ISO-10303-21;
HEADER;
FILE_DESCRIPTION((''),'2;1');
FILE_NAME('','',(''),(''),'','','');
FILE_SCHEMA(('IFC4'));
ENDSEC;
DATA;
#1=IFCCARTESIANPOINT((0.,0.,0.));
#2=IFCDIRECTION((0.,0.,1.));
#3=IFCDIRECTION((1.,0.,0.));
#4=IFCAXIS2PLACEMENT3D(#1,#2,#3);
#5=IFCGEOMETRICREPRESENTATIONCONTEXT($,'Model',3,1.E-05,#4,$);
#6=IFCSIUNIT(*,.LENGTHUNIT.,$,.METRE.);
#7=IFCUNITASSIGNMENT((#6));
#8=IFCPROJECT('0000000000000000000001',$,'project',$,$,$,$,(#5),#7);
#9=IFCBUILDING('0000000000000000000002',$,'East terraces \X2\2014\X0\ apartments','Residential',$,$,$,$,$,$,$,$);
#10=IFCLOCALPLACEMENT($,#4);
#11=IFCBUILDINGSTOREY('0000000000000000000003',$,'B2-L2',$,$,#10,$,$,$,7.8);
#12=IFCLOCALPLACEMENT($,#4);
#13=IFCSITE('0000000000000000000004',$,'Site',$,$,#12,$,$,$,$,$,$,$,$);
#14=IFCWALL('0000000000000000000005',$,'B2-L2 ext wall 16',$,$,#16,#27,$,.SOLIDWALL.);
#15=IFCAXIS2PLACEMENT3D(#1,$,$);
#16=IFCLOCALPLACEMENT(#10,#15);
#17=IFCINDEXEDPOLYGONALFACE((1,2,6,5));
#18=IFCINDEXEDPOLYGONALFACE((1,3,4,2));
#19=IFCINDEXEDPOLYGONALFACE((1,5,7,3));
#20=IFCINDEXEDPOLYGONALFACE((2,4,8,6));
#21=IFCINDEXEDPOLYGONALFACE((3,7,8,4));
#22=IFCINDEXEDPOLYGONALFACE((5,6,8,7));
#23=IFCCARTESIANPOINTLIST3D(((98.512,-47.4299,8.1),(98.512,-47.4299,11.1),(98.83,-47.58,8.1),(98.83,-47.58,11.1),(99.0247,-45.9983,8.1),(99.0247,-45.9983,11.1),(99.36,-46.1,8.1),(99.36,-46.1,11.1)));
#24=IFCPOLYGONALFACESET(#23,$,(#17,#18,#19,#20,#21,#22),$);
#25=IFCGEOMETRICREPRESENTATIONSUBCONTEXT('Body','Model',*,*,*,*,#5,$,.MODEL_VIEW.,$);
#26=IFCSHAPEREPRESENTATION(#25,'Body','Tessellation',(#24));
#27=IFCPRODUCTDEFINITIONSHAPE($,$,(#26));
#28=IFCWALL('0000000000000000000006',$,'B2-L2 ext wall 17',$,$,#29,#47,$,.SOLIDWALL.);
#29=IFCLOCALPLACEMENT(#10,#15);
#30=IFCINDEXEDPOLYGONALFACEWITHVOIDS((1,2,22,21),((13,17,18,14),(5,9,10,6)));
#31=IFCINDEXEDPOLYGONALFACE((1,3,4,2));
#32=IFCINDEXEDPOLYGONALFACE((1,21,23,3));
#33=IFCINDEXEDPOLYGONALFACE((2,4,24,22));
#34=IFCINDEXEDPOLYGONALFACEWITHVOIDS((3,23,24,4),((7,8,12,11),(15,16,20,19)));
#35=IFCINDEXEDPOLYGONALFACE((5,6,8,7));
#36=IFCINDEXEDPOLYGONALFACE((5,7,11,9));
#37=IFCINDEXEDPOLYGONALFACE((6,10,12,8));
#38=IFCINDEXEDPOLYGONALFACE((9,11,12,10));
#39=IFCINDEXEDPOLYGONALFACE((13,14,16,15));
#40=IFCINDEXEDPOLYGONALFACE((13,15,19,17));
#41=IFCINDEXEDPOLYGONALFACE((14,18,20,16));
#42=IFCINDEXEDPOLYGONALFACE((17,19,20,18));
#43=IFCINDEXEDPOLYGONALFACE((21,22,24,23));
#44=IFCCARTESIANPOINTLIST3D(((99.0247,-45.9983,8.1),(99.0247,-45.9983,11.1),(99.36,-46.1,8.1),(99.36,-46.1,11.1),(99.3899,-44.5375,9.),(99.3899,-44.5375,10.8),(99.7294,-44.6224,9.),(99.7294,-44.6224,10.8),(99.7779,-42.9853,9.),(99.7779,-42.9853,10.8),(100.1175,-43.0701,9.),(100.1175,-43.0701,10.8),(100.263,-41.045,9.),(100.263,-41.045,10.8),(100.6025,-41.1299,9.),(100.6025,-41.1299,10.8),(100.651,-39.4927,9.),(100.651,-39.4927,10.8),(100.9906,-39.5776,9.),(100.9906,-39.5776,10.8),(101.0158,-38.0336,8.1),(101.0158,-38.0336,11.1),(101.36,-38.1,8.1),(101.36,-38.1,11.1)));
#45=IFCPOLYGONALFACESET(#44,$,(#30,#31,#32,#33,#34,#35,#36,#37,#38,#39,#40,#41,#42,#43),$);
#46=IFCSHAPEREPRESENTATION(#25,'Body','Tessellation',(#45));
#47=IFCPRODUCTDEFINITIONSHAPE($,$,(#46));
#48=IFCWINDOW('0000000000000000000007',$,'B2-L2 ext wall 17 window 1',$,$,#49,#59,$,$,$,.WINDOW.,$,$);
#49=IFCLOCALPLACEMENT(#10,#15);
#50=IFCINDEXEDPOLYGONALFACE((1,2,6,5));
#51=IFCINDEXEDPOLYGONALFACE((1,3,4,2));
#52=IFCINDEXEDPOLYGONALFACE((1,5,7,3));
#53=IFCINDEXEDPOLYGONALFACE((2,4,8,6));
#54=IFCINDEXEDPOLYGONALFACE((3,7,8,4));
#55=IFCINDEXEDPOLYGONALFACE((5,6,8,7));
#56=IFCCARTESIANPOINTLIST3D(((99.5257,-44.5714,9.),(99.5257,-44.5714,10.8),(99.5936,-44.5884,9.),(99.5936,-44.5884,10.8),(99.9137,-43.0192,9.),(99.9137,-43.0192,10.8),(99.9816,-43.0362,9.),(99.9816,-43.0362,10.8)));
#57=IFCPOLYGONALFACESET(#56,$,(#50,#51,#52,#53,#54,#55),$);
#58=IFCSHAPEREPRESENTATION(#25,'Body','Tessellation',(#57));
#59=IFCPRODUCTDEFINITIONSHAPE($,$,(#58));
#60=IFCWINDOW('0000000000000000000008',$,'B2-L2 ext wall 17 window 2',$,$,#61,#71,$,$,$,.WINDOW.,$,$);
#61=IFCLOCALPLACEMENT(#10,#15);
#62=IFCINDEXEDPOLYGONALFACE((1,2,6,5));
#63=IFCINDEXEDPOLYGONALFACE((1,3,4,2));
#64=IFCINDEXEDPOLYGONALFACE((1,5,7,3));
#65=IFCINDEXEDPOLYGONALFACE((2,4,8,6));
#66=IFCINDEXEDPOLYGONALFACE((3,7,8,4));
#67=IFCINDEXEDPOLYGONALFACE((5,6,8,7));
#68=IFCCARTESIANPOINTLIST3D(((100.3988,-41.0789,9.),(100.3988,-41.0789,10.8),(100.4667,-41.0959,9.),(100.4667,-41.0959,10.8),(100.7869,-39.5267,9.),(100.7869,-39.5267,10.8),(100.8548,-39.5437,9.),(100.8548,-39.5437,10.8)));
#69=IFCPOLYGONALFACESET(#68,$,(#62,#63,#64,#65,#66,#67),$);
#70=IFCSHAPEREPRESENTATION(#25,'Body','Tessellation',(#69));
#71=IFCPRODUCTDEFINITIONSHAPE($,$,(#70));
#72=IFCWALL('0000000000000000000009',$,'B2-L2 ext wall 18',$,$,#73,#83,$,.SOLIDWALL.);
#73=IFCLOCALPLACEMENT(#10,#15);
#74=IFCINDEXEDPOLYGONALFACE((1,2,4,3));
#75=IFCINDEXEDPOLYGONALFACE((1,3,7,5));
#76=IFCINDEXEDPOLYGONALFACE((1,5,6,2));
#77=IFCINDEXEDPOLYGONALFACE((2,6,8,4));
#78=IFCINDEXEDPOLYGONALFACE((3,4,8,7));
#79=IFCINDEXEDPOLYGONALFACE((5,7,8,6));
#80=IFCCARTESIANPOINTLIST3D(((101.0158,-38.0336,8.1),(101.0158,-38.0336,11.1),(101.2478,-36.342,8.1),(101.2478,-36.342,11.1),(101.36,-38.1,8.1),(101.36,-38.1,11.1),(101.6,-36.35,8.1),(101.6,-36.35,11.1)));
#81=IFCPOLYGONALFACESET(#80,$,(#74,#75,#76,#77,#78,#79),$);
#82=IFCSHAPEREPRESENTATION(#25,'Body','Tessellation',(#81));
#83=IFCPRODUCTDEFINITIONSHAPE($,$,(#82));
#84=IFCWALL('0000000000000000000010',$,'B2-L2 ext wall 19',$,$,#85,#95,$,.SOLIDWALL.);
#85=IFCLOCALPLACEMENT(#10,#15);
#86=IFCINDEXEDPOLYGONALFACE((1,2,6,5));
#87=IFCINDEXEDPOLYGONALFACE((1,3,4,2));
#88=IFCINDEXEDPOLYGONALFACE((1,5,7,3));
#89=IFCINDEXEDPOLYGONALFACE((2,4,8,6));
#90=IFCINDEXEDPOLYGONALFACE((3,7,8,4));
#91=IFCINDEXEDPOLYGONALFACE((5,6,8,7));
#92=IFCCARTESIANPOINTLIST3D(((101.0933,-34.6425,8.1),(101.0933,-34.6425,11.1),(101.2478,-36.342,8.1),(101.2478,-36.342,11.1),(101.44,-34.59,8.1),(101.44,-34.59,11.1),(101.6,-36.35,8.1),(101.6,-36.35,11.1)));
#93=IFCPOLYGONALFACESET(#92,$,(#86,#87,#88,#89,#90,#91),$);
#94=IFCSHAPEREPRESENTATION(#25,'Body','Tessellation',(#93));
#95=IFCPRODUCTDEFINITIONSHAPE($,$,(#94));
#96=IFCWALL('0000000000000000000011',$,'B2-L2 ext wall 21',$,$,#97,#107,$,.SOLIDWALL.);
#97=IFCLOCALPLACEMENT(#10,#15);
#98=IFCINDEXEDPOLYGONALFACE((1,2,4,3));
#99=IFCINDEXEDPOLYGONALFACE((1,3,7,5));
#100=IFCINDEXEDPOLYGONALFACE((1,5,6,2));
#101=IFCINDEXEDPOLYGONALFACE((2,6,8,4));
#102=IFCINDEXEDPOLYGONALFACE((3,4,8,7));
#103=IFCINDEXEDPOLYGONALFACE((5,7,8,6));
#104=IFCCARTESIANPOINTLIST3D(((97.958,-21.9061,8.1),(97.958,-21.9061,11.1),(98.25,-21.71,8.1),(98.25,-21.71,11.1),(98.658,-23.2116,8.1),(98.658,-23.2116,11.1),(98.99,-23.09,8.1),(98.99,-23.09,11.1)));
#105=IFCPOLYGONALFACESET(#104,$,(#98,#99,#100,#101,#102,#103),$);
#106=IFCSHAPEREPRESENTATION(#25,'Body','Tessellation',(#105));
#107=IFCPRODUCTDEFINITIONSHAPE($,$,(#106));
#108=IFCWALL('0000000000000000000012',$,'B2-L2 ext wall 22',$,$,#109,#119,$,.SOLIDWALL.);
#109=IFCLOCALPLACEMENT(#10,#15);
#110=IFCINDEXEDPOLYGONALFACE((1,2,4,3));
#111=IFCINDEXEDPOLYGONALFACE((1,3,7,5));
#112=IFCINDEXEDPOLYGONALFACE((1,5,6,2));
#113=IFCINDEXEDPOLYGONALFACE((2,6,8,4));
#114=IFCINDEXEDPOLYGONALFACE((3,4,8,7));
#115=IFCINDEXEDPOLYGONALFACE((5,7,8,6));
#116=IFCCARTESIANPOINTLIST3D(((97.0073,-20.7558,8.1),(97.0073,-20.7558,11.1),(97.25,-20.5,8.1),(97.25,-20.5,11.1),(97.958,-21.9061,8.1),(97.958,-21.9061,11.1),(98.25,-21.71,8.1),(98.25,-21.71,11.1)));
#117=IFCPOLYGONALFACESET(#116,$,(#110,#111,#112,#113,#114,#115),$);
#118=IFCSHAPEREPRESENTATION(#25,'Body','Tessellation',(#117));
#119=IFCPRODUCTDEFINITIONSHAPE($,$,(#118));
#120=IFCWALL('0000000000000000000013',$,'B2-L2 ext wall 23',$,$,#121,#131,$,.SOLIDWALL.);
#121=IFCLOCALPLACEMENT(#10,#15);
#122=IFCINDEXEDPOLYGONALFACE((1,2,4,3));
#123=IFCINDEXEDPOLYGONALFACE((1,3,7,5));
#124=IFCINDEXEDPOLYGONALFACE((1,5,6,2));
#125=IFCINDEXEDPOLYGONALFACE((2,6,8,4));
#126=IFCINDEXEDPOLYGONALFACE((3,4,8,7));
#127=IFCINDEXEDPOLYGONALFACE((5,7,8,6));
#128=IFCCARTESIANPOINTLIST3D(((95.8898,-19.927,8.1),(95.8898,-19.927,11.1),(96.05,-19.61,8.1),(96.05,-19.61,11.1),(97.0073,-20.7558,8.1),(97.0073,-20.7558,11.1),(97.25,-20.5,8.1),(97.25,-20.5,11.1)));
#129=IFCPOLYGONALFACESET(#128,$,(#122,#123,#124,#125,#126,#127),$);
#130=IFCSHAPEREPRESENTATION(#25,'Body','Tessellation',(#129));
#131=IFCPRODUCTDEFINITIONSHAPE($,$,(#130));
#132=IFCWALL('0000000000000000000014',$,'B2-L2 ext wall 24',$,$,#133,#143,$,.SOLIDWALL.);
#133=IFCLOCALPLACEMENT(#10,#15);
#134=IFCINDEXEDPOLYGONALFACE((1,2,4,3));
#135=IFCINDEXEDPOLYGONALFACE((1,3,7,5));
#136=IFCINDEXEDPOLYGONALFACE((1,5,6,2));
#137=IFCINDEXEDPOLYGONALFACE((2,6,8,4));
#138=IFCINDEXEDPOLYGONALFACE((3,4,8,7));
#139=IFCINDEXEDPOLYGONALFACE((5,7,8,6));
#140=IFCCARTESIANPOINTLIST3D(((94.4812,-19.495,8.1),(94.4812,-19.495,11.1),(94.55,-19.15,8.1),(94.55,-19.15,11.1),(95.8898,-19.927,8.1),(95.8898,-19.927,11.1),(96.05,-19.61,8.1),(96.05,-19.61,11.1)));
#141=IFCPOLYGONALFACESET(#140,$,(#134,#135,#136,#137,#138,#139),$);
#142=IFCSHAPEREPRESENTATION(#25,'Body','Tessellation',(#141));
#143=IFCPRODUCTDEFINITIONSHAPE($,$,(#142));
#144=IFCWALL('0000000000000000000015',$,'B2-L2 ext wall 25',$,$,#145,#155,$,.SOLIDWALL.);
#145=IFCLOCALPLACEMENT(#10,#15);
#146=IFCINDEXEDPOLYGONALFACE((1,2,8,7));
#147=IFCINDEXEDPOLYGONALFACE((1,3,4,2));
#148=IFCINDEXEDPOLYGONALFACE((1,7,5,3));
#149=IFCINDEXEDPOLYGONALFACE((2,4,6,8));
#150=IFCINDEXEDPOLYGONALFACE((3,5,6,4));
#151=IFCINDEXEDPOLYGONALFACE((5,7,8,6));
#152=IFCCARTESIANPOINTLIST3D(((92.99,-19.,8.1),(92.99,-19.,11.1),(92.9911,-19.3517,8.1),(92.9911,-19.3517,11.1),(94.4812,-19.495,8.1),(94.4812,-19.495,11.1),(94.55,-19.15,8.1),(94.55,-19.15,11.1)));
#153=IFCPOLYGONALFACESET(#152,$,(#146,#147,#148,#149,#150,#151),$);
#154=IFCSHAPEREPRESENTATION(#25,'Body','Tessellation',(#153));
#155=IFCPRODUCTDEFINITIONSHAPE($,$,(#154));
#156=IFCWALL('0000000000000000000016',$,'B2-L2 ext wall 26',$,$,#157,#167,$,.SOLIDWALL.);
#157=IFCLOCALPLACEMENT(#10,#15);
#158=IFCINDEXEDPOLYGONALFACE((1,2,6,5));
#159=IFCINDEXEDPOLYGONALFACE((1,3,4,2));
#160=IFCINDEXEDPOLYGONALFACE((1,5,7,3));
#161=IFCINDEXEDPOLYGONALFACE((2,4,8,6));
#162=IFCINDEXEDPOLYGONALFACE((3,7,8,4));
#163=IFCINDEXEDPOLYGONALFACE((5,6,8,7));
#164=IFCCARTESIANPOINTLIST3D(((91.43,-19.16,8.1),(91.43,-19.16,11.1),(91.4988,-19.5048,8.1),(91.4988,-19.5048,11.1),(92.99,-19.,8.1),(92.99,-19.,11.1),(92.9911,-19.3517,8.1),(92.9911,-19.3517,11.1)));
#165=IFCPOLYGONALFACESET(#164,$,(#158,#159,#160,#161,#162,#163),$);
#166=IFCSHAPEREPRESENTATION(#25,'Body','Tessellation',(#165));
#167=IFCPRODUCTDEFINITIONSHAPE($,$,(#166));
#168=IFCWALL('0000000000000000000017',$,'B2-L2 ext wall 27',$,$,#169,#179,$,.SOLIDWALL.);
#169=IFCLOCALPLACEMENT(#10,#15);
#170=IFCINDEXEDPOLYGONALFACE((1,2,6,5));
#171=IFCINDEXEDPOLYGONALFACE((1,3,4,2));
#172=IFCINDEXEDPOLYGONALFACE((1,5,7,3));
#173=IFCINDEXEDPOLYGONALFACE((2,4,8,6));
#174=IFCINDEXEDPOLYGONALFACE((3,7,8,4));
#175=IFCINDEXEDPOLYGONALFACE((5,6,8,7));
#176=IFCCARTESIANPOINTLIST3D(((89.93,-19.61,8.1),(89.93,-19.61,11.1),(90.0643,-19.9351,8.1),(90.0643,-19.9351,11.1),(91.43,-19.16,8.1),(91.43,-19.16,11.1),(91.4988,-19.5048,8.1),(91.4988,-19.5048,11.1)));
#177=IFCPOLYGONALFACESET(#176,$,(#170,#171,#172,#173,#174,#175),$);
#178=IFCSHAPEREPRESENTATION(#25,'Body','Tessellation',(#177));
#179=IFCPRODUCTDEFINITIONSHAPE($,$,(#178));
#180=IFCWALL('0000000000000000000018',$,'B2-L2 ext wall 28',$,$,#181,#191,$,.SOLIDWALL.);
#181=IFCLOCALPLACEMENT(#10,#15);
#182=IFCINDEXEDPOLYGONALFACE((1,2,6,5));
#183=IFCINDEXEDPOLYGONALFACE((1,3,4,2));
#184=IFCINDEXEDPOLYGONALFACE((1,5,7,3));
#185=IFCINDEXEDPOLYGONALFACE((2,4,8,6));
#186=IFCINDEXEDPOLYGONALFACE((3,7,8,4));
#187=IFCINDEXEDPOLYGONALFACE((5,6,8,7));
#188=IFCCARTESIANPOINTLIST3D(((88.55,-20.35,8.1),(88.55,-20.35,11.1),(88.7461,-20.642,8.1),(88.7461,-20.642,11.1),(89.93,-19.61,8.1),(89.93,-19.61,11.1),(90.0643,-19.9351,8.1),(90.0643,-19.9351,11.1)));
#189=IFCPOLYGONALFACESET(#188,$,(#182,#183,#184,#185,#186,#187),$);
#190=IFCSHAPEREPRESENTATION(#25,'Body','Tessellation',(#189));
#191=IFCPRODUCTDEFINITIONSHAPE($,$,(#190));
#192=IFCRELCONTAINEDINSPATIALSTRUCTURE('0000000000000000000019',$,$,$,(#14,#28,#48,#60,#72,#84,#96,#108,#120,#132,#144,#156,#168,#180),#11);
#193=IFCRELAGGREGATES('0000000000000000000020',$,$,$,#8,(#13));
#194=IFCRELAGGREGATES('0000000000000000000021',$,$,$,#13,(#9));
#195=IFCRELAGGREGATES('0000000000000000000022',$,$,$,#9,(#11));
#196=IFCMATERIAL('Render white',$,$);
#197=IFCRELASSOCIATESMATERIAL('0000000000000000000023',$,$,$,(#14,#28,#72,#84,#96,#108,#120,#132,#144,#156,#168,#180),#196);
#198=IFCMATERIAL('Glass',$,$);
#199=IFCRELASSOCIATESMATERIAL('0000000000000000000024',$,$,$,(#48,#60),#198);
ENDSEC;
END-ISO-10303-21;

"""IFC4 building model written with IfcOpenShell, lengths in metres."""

from ifc_helpers import new_model, si_unit, frame, origin_with_axes, place, context, subcontext, project, spatial, polyline, outline, extrude, material, element, fill, save


model = new_model("IFC4")

# Units and contexts
model_context = context("Model", 3, precision=1e-05, world=origin_with_axes())
body_context = subcontext(model_context, "Body", "Model", "MODEL_VIEW")
ifc_project = project(units=[si_unit("LENGTHUNIT", "METRE")], contexts=[model_context])

# Site, building, storey
site_placement = place(None, origin_with_axes())
site = spatial("IfcSite", under=ifc_project, at=site_placement, Name="Site")
building = spatial("IfcBuilding", under=site, Name="East terraces — apartments", Description="Residential")
storey_placement = place(None, origin_with_axes())
storey = spatial("IfcBuildingStorey", under=building, at=storey_placement, Name="B2-L2", Elevation=7.8)

# Wall
ifc_material_1 = material(Name="Render white")
wall_1_placement = place(storey_placement, origin_with_axes())
element("IfcWall", 1, at=wall_1_placement, inside=storey, material=ifc_material_1, Name="B2-L2 ext wall 16", PredefinedType="SOLIDWALL", context=body_context, shape_type="SweptSolid", body=[
    extrude(outline(polyline([(98.83, -47.58), (99.36, -46.1), (99.0247, -45.9983), (98.512, -47.4299), (98.83, -47.58)])), frame((0.0, 0.0, 8.1), z_axis=(0.0, 0.0, 1.0), x_axis=(1.0, 0.0, 0.0)), (0.0, 0.0, 1.0), 3.0),
])

# Wall, openings, windows
wall_2_placement = place(storey_placement, origin_with_axes())
wall_2 = element("IfcWall", 2, at=wall_2_placement, inside=storey, material=ifc_material_1, Name="B2-L2 ext wall 17", PredefinedType="SOLIDWALL", context=body_context, shape_type="SweptSolid", body=[
    extrude(outline(polyline([(99.36, -46.1), (101.36, -38.1), (101.0158, -38.0336), (99.0247, -45.9983), (99.36, -46.1)])), frame((0.0, 0.0, 8.1), z_axis=(0.0, 0.0, 1.0), x_axis=(1.0, 0.0, 0.0)), (0.0, 0.0, 1.0), 3.0),
])
opening_1_placement = place(wall_2_placement, origin_with_axes())
opening_1 = element("IfcOpeningElement", 3, at=opening_1_placement, cuts=wall_2, context=body_context, shape_type="SweptSolid", body=[
    extrude(outline(polyline([(99.7779, -44.6345), (100.166, -43.0823), (99.7294, -42.9731), (99.3414, -44.5254), (99.7779, -44.6345)])), frame((0.0, 0.0, 9.0), z_axis=(0.0, 0.0, 1.0), x_axis=(1.0, 0.0, 0.0)), (0.0, 0.0, 1.0), 1.8),
])
opening_2_placement = place(wall_2_placement, origin_with_axes())
opening_2 = element("IfcOpeningElement", 4, at=opening_2_placement, cuts=wall_2, context=body_context, shape_type="SweptSolid", body=[
    extrude(outline(polyline([(100.651, -41.142), (101.0391, -39.5898), (100.6025, -39.4806), (100.2145, -41.0328), (100.651, -41.142)])), frame((0.0, 0.0, 9.0), z_axis=(0.0, 0.0, 1.0), x_axis=(1.0, 0.0, 0.0)), (0.0, 0.0, 1.0), 1.8),
])
ifc_material_2 = material(Name="Glass")
window_1_placement = place(storey_placement, origin_with_axes())
window_1 = element("IfcWindow", 5, at=window_1_placement, inside=storey, material=ifc_material_2, Name="B2-L2 ext wall 17 window 1", PredefinedType="WINDOW", context=body_context, shape_type="SweptSolid", body=[
    extrude(outline(polyline([(99.5936, -44.5884), (99.9816, -43.0362), (99.9137, -43.0192), (99.5257, -44.5714), (99.5936, -44.5884)])), frame((0.0, 0.0, 9.0), z_axis=(0.0, 0.0, 1.0), x_axis=(1.0, 0.0, 0.0)), (0.0, 0.0, 1.0), 1.8),
])
fill(opening_1, window_1)
window_2_placement = place(storey_placement, origin_with_axes())
window_2 = element("IfcWindow", 6, at=window_2_placement, inside=storey, material=ifc_material_2, Name="B2-L2 ext wall 17 window 2", PredefinedType="WINDOW", context=body_context, shape_type="SweptSolid", body=[
    extrude(outline(polyline([(100.4667, -41.0959), (100.8548, -39.5437), (100.7869, -39.5267), (100.3988, -41.0789), (100.4667, -41.0959)])), frame((0.0, 0.0, 9.0), z_axis=(0.0, 0.0, 1.0), x_axis=(1.0, 0.0, 0.0)), (0.0, 0.0, 1.0), 1.8),
])
fill(opening_2, window_2)

# Walls
wall_3_placement = place(storey_placement, origin_with_axes())
element("IfcWall", 7, at=wall_3_placement, inside=storey, material=ifc_material_1, Name="B2-L2 ext wall 18", PredefinedType="SOLIDWALL", context=body_context, shape_type="SweptSolid", body=[
    extrude(outline(polyline([(101.36, -38.1), (101.6, -36.35), (101.2478, -36.342), (101.0158, -38.0336), (101.36, -38.1)])), frame((0.0, 0.0, 8.1), z_axis=(0.0, 0.0, 1.0), x_axis=(1.0, 0.0, 0.0)), (0.0, 0.0, 1.0), 3.0),
])
wall_4_placement = place(storey_placement, origin_with_axes())
element("IfcWall", 8, at=wall_4_placement, inside=storey, material=ifc_material_1, Name="B2-L2 ext wall 19", PredefinedType="SOLIDWALL", context=body_context, shape_type="SweptSolid", body=[
    extrude(outline(polyline([(101.6, -36.35), (101.44, -34.59), (101.0933, -34.6425), (101.2478, -36.342), (101.6, -36.35)])), frame((0.0, 0.0, 8.1), z_axis=(0.0, 0.0, 1.0), x_axis=(1.0, 0.0, 0.0)), (0.0, 0.0, 1.0), 3.0),
])

# Walls
wall_5_placement = place(storey_placement, origin_with_axes())
element("IfcWall", 9, at=wall_5_placement, inside=storey, material=ifc_material_1, Name="B2-L2 ext wall 21", PredefinedType="SOLIDWALL", context=body_context, shape_type="SweptSolid", body=[
    extrude(outline(polyline([(98.99, -23.09), (98.25, -21.71), (97.958, -21.9061), (98.658, -23.2116), (98.99, -23.09)])), frame((0.0, 0.0, 8.1), z_axis=(0.0, 0.0, 1.0), x_axis=(1.0, 0.0, 0.0)), (0.0, 0.0, 1.0), 3.0),
])
wall_6_placement = place(storey_placement, origin_with_axes())
element("IfcWall", 10, at=wall_6_placement, inside=storey, material=ifc_material_1, Name="B2-L2 ext wall 22", PredefinedType="SOLIDWALL", context=body_context, shape_type="SweptSolid", body=[
    extrude(outline(polyline([(98.25, -21.71), (97.25, -20.5), (97.0073, -20.7558), (97.958, -21.9061), (98.25, -21.71)])), frame((0.0, 0.0, 8.1), z_axis=(0.0, 0.0, 1.0), x_axis=(1.0, 0.0, 0.0)), (0.0, 0.0, 1.0), 3.0),
])
wall_7_placement = place(storey_placement, origin_with_axes())
element("IfcWall", 11, at=wall_7_placement, inside=storey, material=ifc_material_1, Name="B2-L2 ext wall 23", PredefinedType="SOLIDWALL", context=body_context, shape_type="SweptSolid", body=[
    extrude(outline(polyline([(97.25, -20.5), (96.05, -19.61), (95.8898, -19.927), (97.0073, -20.7558), (97.25, -20.5)])), frame((0.0, 0.0, 8.1), z_axis=(0.0, 0.0, 1.0), x_axis=(1.0, 0.0, 0.0)), (0.0, 0.0, 1.0), 3.0),
])
wall_8_placement = place(storey_placement, origin_with_axes())
element("IfcWall", 12, at=wall_8_placement, inside=storey, material=ifc_material_1, Name="B2-L2 ext wall 24", PredefinedType="SOLIDWALL", context=body_context, shape_type="SweptSolid", body=[
    extrude(outline(polyline([(96.05, -19.61), (94.55, -19.15), (94.4812, -19.495), (95.8898, -19.927), (96.05, -19.61)])), frame((0.0, 0.0, 8.1), z_axis=(0.0, 0.0, 1.0), x_axis=(1.0, 0.0, 0.0)), (0.0, 0.0, 1.0), 3.0),
])
wall_9_placement = place(storey_placement, origin_with_axes())
element("IfcWall", 13, at=wall_9_placement, inside=storey, material=ifc_material_1, Name="B2-L2 ext wall 25", PredefinedType="SOLIDWALL", context=body_context, shape_type="SweptSolid", body=[
    extrude(outline(polyline([(94.55, -19.15), (92.99, -19.0), (92.9911, -19.3517), (94.4812, -19.495), (94.55, -19.15)])), frame((0.0, 0.0, 8.1), z_axis=(0.0, 0.0, 1.0), x_axis=(1.0, 0.0, 0.0)), (0.0, 0.0, 1.0), 3.0),
])
wall_10_placement = place(storey_placement, origin_with_axes())
element("IfcWall", 14, at=wall_10_placement, inside=storey, material=ifc_material_1, Name="B2-L2 ext wall 26", PredefinedType="SOLIDWALL", context=body_context, shape_type="SweptSolid", body=[
    extrude(outline(polyline([(92.99, -19.0), (91.43, -19.16), (91.4988, -19.5048), (92.9911, -19.3517), (92.99, -19.0)])), frame((0.0, 0.0, 8.1), z_axis=(0.0, 0.0, 1.0), x_axis=(1.0, 0.0, 0.0)), (0.0, 0.0, 1.0), 3.0),
])
wall_11_placement = place(storey_placement, origin_with_axes())
element("IfcWall", 15, at=wall_11_placement, inside=storey, material=ifc_material_1, Name="B2-L2 ext wall 27", PredefinedType="SOLIDWALL", context=body_context, shape_type="SweptSolid", body=[
    extrude(outline(polyline([(91.43, -19.16), (89.93, -19.61), (90.0643, -19.9351), (91.4988, -19.5048), (91.43, -19.16)])), frame((0.0, 0.0, 8.1), z_axis=(0.0, 0.0, 1.0), x_axis=(1.0, 0.0, 0.0)), (0.0, 0.0, 1.0), 3.0),
])
wall_12_placement = place(storey_placement, origin_with_axes())
element("IfcWall", 16, at=wall_12_placement, inside=storey, material=ifc_material_1, Name="B2-L2 ext wall 28", PredefinedType="SOLIDWALL", context=body_context, shape_type="SweptSolid", body=[
    extrude(outline(polyline([(89.93, -19.61), (88.55, -20.35), (88.7461, -20.642), (90.0643, -19.9351), (89.93, -19.61)])), frame((0.0, 0.0, 8.1), z_axis=(0.0, 0.0, 1.0), x_axis=(1.0, 0.0, 0.0)), (0.0, 0.0, 1.0), 3.0),
])

save(model, "model.ifc")
